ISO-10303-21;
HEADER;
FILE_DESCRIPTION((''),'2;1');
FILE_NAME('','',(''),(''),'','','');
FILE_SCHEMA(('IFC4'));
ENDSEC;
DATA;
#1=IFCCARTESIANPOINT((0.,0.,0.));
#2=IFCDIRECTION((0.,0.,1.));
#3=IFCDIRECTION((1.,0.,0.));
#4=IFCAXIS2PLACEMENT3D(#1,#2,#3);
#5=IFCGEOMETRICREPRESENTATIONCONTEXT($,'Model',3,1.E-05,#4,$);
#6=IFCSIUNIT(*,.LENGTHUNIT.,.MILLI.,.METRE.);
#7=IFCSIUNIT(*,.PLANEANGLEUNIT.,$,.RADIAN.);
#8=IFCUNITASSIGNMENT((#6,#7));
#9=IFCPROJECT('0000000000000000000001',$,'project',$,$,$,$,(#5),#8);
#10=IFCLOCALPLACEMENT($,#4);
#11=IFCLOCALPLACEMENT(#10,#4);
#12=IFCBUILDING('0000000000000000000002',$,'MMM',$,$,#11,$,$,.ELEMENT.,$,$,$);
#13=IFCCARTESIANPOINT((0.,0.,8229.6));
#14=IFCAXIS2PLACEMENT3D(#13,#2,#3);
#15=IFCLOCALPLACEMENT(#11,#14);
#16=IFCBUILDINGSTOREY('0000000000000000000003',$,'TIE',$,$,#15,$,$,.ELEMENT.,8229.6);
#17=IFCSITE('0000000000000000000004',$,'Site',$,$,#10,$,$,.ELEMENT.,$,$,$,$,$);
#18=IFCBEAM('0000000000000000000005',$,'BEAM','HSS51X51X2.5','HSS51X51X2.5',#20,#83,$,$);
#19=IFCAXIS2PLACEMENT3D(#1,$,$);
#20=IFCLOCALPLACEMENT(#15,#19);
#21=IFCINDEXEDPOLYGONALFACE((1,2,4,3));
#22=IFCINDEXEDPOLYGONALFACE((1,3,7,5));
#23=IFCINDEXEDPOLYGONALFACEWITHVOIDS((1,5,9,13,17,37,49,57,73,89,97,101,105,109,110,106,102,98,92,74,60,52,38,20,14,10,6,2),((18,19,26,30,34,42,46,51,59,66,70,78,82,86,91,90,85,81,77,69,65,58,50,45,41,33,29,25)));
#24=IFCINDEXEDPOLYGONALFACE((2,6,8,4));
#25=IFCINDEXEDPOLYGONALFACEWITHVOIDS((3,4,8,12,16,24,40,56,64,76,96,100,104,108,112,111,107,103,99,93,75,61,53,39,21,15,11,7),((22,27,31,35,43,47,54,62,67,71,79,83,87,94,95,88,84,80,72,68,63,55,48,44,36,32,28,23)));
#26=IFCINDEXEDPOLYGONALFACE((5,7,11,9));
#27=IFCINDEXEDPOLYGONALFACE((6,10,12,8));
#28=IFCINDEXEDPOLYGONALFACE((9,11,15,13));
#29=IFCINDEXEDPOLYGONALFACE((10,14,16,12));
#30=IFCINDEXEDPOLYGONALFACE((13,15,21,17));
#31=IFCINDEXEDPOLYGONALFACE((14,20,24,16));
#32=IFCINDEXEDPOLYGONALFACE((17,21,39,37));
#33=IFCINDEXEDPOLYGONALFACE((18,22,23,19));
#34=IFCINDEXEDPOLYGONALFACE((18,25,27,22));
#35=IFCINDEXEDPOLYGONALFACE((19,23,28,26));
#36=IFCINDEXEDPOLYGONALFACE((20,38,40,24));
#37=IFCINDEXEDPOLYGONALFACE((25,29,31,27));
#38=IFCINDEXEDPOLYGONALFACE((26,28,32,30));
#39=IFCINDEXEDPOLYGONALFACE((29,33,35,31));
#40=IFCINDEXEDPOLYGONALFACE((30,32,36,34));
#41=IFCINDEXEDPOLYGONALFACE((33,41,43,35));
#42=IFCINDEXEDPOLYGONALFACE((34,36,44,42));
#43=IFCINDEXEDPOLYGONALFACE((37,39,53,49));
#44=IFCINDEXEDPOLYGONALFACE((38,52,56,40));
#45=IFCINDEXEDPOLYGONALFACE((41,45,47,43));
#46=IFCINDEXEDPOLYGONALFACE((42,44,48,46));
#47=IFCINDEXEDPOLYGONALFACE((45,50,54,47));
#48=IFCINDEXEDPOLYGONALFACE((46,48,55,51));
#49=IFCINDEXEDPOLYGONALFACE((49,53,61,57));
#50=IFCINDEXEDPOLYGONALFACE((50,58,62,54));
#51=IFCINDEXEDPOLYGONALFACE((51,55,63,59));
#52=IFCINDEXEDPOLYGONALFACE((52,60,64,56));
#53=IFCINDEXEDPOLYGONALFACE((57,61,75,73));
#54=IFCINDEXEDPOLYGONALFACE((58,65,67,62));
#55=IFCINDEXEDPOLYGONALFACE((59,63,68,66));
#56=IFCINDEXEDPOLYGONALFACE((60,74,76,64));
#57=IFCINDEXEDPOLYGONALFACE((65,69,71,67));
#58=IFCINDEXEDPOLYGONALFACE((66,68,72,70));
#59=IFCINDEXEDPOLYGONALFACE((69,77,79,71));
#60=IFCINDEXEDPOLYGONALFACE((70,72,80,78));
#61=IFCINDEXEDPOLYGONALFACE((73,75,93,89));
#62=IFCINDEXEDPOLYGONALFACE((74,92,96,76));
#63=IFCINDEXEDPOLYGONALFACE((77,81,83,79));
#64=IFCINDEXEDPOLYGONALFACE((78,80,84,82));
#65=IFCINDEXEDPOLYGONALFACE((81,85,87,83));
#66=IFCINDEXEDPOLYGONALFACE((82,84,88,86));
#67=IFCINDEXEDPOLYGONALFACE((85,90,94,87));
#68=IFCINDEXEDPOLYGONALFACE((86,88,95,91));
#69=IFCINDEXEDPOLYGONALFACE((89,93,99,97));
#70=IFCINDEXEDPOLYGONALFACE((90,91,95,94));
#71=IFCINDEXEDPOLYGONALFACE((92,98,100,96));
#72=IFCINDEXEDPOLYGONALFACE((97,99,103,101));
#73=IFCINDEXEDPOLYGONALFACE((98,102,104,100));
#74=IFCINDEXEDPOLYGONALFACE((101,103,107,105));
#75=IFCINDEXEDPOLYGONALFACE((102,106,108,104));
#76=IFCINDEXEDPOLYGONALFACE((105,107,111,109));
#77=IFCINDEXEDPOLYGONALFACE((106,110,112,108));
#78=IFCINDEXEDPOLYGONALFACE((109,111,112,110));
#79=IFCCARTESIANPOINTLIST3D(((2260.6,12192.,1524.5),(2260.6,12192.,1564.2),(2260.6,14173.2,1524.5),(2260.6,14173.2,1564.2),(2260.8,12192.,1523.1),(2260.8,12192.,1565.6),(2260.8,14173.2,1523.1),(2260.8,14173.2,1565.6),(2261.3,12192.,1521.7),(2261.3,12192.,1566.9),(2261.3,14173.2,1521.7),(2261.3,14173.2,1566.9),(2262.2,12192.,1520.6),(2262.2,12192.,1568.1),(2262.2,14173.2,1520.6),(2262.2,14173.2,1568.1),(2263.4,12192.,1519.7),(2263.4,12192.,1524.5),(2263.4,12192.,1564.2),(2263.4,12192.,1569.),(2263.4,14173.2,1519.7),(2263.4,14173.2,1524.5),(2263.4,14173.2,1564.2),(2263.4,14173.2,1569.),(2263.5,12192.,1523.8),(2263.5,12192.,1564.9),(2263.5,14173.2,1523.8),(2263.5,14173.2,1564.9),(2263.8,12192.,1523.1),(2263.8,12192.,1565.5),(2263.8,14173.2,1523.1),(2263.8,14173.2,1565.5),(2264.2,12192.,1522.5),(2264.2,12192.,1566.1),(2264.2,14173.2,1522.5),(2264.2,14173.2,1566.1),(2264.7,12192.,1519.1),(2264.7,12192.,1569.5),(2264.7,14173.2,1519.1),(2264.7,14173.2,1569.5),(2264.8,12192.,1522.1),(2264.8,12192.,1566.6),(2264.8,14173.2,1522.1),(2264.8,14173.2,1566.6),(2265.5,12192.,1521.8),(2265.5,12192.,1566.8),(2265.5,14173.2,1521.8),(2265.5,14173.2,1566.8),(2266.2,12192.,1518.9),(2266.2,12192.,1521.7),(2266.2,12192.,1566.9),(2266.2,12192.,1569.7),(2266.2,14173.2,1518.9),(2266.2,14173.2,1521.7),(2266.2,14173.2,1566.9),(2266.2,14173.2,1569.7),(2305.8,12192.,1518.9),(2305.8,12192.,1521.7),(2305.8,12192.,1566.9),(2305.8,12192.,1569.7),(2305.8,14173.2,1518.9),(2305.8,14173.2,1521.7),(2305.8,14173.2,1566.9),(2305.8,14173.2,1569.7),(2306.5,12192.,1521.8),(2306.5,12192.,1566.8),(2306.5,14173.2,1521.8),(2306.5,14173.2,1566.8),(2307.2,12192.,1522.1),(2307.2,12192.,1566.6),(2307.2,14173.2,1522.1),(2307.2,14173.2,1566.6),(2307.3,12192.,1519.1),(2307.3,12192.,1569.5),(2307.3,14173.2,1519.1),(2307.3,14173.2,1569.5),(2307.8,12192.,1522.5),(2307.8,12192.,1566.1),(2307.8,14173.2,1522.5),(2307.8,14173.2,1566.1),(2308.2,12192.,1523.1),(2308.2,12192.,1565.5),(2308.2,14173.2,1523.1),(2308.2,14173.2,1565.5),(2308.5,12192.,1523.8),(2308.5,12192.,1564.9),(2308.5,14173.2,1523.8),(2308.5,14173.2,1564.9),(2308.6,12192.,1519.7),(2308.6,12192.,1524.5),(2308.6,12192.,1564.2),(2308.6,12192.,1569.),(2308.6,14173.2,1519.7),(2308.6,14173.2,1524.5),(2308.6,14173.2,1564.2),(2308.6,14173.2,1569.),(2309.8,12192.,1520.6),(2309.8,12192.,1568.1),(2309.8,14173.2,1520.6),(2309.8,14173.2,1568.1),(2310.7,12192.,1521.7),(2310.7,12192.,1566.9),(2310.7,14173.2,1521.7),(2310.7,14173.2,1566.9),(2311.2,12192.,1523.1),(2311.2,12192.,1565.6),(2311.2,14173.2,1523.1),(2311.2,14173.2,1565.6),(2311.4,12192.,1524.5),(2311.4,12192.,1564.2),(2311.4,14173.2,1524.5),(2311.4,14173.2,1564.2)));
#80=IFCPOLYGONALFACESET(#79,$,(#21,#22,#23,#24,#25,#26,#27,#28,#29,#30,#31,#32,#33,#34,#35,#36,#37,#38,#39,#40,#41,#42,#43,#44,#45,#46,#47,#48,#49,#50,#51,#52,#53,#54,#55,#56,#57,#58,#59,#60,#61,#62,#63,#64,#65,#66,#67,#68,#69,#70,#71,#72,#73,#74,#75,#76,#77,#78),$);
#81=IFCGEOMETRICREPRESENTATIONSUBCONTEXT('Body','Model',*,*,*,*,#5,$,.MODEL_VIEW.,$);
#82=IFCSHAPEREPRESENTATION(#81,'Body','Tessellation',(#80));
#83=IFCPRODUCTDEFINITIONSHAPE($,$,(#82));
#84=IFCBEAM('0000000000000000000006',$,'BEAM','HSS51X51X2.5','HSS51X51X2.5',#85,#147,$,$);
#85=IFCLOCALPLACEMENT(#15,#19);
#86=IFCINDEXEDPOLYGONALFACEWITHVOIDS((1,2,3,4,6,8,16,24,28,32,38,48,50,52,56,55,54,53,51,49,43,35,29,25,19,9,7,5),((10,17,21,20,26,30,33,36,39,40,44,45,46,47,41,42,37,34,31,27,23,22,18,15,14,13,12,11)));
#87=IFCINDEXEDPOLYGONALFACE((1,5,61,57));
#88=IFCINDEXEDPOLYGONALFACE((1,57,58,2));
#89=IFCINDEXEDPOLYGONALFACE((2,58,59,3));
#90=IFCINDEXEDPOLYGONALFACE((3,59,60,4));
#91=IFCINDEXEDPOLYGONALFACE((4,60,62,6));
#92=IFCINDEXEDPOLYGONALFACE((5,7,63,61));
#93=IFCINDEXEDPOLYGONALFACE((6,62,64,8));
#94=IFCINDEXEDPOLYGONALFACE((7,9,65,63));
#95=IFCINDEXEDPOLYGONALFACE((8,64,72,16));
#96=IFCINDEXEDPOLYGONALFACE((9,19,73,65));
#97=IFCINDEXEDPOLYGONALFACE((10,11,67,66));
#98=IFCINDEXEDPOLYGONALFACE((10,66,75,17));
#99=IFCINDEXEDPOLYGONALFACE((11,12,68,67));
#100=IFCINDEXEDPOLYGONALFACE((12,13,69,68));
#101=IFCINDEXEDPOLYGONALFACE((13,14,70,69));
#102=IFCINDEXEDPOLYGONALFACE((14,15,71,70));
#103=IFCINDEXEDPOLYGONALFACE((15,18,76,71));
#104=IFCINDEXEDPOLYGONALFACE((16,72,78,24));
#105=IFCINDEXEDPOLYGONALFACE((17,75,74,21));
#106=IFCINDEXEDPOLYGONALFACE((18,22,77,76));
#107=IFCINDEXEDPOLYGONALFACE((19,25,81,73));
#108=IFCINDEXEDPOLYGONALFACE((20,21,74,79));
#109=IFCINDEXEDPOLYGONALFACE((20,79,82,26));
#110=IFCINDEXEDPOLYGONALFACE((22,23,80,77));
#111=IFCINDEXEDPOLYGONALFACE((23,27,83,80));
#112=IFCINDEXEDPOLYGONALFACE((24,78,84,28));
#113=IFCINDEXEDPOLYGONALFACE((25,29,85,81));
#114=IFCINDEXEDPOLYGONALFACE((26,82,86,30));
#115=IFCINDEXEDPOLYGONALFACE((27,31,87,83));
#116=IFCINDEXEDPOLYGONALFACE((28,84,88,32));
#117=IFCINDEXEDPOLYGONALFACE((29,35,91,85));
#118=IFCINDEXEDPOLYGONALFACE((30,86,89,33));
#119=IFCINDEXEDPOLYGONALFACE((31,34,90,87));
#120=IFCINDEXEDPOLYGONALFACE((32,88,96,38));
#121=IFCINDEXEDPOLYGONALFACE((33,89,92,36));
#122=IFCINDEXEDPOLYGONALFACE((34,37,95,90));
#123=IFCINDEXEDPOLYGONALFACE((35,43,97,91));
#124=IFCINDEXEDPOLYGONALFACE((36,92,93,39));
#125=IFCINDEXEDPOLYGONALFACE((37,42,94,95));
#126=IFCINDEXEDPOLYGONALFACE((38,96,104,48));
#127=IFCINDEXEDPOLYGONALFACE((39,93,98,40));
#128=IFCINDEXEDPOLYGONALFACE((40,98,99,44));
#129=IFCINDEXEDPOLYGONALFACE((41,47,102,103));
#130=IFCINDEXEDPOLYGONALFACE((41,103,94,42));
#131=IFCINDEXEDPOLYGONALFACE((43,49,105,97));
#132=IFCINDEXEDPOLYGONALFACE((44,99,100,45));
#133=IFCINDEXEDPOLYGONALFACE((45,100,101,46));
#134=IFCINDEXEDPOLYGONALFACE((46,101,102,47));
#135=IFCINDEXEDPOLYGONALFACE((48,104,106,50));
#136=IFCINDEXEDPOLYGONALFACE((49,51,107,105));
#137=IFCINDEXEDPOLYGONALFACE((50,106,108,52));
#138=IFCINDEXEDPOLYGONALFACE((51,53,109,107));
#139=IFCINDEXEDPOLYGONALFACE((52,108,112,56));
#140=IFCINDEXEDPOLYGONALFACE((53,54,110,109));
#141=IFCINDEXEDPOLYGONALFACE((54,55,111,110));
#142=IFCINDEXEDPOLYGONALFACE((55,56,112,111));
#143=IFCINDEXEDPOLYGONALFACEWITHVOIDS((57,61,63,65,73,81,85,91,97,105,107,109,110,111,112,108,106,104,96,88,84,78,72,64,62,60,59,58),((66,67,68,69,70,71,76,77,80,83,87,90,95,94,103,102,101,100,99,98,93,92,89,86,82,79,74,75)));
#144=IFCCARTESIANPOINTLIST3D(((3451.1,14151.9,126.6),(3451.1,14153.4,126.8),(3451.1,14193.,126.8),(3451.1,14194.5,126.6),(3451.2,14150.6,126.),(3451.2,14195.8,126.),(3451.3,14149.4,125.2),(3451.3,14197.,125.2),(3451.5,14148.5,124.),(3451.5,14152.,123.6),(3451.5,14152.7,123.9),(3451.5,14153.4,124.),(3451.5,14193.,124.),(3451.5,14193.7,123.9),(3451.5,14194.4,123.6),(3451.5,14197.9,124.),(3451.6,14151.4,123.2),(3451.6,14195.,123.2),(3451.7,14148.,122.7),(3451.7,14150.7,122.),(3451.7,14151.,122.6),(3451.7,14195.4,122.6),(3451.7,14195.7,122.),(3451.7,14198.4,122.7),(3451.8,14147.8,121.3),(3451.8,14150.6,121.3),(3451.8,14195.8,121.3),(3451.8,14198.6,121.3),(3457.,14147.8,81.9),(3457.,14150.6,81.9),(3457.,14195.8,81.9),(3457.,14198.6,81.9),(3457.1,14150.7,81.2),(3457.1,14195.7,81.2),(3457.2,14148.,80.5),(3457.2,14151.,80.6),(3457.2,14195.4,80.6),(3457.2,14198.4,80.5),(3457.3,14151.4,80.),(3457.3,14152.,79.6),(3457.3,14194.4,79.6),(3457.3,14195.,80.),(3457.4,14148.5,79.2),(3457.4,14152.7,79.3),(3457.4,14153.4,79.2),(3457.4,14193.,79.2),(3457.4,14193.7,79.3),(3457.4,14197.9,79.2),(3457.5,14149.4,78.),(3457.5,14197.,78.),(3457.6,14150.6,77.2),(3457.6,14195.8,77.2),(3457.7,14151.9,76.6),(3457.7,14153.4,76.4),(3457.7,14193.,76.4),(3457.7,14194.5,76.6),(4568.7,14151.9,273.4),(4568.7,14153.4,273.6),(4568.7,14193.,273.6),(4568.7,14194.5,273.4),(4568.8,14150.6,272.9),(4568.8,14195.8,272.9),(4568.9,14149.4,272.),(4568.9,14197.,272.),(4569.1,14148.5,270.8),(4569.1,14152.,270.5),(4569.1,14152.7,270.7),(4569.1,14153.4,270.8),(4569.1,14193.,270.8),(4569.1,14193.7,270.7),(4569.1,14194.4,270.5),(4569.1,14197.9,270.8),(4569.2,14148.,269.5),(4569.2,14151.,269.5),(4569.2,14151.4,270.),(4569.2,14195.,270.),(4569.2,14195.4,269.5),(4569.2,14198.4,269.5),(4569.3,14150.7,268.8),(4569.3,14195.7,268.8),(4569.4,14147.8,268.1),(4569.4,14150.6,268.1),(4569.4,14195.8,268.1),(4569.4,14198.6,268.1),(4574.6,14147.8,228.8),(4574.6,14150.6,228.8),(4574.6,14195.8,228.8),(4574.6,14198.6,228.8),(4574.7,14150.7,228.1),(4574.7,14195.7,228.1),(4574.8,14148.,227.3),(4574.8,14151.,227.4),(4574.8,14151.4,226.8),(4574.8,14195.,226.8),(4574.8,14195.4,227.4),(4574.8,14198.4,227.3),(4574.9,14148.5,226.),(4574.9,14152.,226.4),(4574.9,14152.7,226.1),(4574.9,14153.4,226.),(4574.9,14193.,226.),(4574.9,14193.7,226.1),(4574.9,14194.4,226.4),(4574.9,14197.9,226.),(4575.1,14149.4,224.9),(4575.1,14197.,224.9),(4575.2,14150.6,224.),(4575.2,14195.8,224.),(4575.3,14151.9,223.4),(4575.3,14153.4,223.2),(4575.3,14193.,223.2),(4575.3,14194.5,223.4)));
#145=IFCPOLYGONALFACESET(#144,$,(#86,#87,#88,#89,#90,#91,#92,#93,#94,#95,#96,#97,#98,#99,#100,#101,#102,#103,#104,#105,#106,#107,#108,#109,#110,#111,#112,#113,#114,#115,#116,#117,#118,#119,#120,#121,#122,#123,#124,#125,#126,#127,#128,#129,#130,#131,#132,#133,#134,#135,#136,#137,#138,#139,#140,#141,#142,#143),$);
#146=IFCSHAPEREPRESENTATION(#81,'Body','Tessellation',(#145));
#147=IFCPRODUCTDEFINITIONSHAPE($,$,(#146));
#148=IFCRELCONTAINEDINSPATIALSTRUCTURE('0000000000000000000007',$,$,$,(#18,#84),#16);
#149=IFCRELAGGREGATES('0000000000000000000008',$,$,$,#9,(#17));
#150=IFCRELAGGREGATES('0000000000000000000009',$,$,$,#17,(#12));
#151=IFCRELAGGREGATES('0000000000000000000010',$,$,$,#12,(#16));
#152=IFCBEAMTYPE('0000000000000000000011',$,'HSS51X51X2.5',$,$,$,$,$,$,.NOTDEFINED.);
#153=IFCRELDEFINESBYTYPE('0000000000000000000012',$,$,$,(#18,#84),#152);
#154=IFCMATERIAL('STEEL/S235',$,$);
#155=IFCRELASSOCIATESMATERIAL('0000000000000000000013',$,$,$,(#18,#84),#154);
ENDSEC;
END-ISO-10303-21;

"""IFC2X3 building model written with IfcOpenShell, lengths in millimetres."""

from ifc_helpers import new_model, si_unit, frame, origin_with_axes, origin_2d_with_axis, place, context, subcontext, project, spatial, hollow_rectangle, extrude, material, type_object, element, save


model = new_model("IFC2X3")

# Units and contexts
model_context = context("Model", 3, precision=1e-05, world=origin_with_axes())
body_context = subcontext(model_context, "Body", "Model", "MODEL_VIEW")
ifc_project = project(units=[si_unit("LENGTHUNIT", "METRE", prefix="MILLI"), si_unit("PLANEANGLEUNIT", "RADIAN")], contexts=[model_context])

# Site, building, storey
site_placement = place(None, origin_with_axes())
site = spatial("IfcSite", under=ifc_project, at=site_placement, Name="Site", CompositionType="ELEMENT")
building_placement = place(site_placement, origin_with_axes())
building = spatial("IfcBuilding", under=site, at=building_placement, Name="MMM", CompositionType="ELEMENT")
storey_placement = place(building_placement, frame((0.0, 0.0, 8229.6), z_axis=(0.0, 0.0, 1.0), x_axis=(1.0, 0.0, 0.0)))
storey = spatial("IfcBuildingStorey", under=building, at=storey_placement, Name="TIE", CompositionType="ELEMENT", Elevation=8229.6)

# Beams
ifc_material = material(Name="STEEL/S235")
beam_type_1 = type_object("IfcBeamType", Name="HSS51X51X2.5", PredefinedType="NOTDEFINED")
beam_1_placement = place(storey_placement, frame((2286.0, 12192.0, 1544.3), z_axis=(0.0, 0.0, 1.0), x_axis=(0.0, 1.0, 0.0)))
element("IfcBeam", 1, at=beam_1_placement, inside=storey, type_object=beam_type_1, material=ifc_material, Name="BEAM", Description="HSS51X51X2.5", ObjectType="HSS51X51X2.5", context=body_context, shape_type="SweptSolid", body=[
    extrude(hollow_rectangle(XDim=50.8, YDim=50.8, WallThickness=2.8, InnerFilletRadius=2.8, OuterFilletRadius=5.6, at=origin_2d_with_axis()), frame((1981.2, 0.0, 0.0), z_axis=(-1.0, 0.0, 0.0), x_axis=(0.0, -1.0, 0.0)), (0.0, 0.0, 1.0), 1981.2),
])
beam_2_placement = place(storey_placement, frame((3454.4, 14173.2, 101.6), z_axis=(-0.130258, 0.0, 0.99148), x_axis=(0.99148, 0.0, 0.130258)))
element("IfcBeam", 2, at=beam_2_placement, inside=storey, type_object=beam_type_1, material=ifc_material, Name="BEAM", Description="HSS51X51X2.5", ObjectType="HSS51X51X2.5", context=body_context, shape_type="SweptSolid", body=[
    extrude(hollow_rectangle(XDim=50.8, YDim=50.8, WallThickness=2.8, InnerFilletRadius=2.8, OuterFilletRadius=5.6, at=origin_2d_with_axis()), frame((1127.2, 0.0, 0.0), z_axis=(-1.0, 0.0, 0.0), x_axis=(0.0, -1.0, 0.0)), (0.0, 0.0, 1.0), 1127.2),
])

save(model, "model.ifc")
